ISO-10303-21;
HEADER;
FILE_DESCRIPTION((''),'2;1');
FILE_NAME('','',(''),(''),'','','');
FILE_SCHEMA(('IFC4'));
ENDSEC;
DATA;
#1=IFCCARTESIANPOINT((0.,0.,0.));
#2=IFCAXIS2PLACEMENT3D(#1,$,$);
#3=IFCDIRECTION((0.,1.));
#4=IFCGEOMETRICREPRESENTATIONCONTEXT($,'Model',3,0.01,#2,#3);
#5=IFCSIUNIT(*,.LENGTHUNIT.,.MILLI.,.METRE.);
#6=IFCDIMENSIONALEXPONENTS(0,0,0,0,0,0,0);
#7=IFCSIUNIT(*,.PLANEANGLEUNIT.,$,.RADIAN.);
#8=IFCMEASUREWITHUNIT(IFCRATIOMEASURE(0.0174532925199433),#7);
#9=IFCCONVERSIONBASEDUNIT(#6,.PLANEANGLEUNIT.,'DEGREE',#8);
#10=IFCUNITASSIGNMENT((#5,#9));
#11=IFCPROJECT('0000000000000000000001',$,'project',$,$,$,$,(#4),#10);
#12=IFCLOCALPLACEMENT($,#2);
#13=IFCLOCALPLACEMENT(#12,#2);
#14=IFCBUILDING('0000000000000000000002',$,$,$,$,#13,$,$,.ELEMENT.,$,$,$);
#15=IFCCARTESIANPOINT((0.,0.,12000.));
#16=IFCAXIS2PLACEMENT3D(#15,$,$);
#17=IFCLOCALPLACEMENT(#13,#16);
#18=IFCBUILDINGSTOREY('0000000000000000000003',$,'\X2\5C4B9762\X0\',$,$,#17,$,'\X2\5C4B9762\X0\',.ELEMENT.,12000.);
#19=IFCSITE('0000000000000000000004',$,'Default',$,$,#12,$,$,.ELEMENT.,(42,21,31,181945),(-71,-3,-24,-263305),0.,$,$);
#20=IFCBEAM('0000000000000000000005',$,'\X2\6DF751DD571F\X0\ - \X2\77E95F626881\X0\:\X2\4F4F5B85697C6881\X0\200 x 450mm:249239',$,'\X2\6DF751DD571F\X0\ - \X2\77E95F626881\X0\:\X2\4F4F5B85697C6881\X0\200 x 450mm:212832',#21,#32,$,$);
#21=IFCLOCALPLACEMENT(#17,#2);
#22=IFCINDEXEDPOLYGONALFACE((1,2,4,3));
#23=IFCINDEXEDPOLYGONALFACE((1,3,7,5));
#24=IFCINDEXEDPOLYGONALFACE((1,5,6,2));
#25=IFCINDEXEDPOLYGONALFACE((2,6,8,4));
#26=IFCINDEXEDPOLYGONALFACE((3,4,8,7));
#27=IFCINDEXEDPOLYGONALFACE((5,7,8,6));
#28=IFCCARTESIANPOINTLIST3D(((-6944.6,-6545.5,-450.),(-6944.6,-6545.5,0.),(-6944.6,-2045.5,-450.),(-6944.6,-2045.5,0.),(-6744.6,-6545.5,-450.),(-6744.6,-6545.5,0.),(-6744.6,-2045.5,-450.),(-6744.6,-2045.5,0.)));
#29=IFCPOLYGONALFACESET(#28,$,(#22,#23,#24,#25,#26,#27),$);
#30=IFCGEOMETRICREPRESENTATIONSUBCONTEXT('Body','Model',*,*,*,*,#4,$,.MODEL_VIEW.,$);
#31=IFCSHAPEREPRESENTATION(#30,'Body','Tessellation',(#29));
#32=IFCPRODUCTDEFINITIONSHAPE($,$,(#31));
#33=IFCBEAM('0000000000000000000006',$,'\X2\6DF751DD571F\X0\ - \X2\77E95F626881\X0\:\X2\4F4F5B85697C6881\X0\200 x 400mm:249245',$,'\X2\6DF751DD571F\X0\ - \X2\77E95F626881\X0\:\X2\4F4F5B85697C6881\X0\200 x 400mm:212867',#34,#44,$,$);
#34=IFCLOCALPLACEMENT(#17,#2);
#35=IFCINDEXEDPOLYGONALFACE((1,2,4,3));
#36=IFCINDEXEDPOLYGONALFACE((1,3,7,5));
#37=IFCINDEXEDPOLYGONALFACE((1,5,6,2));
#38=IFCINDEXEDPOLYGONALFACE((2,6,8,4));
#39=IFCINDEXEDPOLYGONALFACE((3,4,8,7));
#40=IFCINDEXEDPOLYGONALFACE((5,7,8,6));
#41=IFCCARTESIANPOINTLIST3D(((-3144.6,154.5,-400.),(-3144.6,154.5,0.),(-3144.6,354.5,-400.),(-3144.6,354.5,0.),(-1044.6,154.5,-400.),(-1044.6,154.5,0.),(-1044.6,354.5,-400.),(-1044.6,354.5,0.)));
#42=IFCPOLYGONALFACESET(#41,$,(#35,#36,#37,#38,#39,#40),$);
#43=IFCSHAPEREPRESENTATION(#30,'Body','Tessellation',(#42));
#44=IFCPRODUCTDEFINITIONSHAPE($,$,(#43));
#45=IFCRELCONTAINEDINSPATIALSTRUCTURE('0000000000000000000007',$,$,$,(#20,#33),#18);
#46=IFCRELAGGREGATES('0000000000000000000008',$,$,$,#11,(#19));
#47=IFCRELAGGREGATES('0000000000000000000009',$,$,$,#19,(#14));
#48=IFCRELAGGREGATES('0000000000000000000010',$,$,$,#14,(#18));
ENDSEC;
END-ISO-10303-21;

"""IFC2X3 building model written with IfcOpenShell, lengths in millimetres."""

from ifc_helpers import new_model, entity, si_unit, converted_unit, direction, frame, frame_2d, origin, place, context, subcontext, project, spatial, rectangle, extrude, element, save


model = new_model("IFC2X3")

# Units and contexts
model_context = context("Model", 3, precision=0.01, world=origin(), true_north=direction((0.0, 1.0)))
body_context = subcontext(model_context, "Body", "Model", "MODEL_VIEW")
ifc_project = project(units=[si_unit("LENGTHUNIT", "METRE", prefix="MILLI"), converted_unit("PLANEANGLEUNIT", "DEGREE", entity("IfcRatioMeasure", 0.0174532925199433), si_unit("PLANEANGLEUNIT", "RADIAN"), dimensions=[0, 0, 0, 0, 0, 0, 0])], contexts=[model_context])

# Site, building, storey
site_placement = place(None, origin())
site = spatial("IfcSite", under=ifc_project, at=site_placement, Name="Default", CompositionType="ELEMENT", RefLatitude=(42, 21, 31, 181945), RefLongitude=(-71, -3, -24, -263305), RefElevation=0.0)
building_placement = place(site_placement, origin())
building = spatial("IfcBuilding", under=site, at=building_placement, CompositionType="ELEMENT")
storey_placement = place(building_placement, frame((0.0, 0.0, 12000.0)))
storey = spatial("IfcBuildingStorey", under=building, at=storey_placement, Name="屋面", LongName="屋面", CompositionType="ELEMENT", Elevation=12000.0)

# Beams
beam_1_placement = place(storey_placement, frame((-6844.6, -1945.5, 0.0), z_axis=(0.0, 0.0, 1.0), x_axis=(0.0, -1.0, 0.0)))
element("IfcBeam", 1, at=beam_1_placement, inside=storey, Name="混凝土 - 矩形梁:住宅楼梁200 x 450mm:249239", ObjectType="混凝土 - 矩形梁:住宅楼梁200 x 450mm:212832", context=body_context, shape_type="SweptSolid", body=[
    extrude(rectangle(XDim=450.0, YDim=200.0, at=frame_2d((0.0, 0.0), x_axis=(1.0, 0.0))), frame((100.0, 0.0, -225.0), z_axis=(1.0, 0.0, 0.0), x_axis=(0.0, 0.0, -1.0)), (0.0, 0.0, 1.0), 4500.0),
])
beam_2_placement = place(storey_placement, frame((-3244.6, 254.5, 0.0)))
element("IfcBeam", 2, at=beam_2_placement, inside=storey, Name="混凝土 - 矩形梁:住宅楼梁200 x 400mm:249245", ObjectType="混凝土 - 矩形梁:住宅楼梁200 x 400mm:212867", context=body_context, shape_type="SweptSolid", body=[
    extrude(rectangle(XDim=400.0, YDim=200.0, at=frame_2d((0.0, 0.0), x_axis=(1.0, 0.0))), frame((100.0, 0.0, -200.0), z_axis=(1.0, 0.0, 0.0), x_axis=(0.0, 0.0, -1.0)), (0.0, 0.0, 1.0), 2100.0),
])

save(model, "model.ifc")
